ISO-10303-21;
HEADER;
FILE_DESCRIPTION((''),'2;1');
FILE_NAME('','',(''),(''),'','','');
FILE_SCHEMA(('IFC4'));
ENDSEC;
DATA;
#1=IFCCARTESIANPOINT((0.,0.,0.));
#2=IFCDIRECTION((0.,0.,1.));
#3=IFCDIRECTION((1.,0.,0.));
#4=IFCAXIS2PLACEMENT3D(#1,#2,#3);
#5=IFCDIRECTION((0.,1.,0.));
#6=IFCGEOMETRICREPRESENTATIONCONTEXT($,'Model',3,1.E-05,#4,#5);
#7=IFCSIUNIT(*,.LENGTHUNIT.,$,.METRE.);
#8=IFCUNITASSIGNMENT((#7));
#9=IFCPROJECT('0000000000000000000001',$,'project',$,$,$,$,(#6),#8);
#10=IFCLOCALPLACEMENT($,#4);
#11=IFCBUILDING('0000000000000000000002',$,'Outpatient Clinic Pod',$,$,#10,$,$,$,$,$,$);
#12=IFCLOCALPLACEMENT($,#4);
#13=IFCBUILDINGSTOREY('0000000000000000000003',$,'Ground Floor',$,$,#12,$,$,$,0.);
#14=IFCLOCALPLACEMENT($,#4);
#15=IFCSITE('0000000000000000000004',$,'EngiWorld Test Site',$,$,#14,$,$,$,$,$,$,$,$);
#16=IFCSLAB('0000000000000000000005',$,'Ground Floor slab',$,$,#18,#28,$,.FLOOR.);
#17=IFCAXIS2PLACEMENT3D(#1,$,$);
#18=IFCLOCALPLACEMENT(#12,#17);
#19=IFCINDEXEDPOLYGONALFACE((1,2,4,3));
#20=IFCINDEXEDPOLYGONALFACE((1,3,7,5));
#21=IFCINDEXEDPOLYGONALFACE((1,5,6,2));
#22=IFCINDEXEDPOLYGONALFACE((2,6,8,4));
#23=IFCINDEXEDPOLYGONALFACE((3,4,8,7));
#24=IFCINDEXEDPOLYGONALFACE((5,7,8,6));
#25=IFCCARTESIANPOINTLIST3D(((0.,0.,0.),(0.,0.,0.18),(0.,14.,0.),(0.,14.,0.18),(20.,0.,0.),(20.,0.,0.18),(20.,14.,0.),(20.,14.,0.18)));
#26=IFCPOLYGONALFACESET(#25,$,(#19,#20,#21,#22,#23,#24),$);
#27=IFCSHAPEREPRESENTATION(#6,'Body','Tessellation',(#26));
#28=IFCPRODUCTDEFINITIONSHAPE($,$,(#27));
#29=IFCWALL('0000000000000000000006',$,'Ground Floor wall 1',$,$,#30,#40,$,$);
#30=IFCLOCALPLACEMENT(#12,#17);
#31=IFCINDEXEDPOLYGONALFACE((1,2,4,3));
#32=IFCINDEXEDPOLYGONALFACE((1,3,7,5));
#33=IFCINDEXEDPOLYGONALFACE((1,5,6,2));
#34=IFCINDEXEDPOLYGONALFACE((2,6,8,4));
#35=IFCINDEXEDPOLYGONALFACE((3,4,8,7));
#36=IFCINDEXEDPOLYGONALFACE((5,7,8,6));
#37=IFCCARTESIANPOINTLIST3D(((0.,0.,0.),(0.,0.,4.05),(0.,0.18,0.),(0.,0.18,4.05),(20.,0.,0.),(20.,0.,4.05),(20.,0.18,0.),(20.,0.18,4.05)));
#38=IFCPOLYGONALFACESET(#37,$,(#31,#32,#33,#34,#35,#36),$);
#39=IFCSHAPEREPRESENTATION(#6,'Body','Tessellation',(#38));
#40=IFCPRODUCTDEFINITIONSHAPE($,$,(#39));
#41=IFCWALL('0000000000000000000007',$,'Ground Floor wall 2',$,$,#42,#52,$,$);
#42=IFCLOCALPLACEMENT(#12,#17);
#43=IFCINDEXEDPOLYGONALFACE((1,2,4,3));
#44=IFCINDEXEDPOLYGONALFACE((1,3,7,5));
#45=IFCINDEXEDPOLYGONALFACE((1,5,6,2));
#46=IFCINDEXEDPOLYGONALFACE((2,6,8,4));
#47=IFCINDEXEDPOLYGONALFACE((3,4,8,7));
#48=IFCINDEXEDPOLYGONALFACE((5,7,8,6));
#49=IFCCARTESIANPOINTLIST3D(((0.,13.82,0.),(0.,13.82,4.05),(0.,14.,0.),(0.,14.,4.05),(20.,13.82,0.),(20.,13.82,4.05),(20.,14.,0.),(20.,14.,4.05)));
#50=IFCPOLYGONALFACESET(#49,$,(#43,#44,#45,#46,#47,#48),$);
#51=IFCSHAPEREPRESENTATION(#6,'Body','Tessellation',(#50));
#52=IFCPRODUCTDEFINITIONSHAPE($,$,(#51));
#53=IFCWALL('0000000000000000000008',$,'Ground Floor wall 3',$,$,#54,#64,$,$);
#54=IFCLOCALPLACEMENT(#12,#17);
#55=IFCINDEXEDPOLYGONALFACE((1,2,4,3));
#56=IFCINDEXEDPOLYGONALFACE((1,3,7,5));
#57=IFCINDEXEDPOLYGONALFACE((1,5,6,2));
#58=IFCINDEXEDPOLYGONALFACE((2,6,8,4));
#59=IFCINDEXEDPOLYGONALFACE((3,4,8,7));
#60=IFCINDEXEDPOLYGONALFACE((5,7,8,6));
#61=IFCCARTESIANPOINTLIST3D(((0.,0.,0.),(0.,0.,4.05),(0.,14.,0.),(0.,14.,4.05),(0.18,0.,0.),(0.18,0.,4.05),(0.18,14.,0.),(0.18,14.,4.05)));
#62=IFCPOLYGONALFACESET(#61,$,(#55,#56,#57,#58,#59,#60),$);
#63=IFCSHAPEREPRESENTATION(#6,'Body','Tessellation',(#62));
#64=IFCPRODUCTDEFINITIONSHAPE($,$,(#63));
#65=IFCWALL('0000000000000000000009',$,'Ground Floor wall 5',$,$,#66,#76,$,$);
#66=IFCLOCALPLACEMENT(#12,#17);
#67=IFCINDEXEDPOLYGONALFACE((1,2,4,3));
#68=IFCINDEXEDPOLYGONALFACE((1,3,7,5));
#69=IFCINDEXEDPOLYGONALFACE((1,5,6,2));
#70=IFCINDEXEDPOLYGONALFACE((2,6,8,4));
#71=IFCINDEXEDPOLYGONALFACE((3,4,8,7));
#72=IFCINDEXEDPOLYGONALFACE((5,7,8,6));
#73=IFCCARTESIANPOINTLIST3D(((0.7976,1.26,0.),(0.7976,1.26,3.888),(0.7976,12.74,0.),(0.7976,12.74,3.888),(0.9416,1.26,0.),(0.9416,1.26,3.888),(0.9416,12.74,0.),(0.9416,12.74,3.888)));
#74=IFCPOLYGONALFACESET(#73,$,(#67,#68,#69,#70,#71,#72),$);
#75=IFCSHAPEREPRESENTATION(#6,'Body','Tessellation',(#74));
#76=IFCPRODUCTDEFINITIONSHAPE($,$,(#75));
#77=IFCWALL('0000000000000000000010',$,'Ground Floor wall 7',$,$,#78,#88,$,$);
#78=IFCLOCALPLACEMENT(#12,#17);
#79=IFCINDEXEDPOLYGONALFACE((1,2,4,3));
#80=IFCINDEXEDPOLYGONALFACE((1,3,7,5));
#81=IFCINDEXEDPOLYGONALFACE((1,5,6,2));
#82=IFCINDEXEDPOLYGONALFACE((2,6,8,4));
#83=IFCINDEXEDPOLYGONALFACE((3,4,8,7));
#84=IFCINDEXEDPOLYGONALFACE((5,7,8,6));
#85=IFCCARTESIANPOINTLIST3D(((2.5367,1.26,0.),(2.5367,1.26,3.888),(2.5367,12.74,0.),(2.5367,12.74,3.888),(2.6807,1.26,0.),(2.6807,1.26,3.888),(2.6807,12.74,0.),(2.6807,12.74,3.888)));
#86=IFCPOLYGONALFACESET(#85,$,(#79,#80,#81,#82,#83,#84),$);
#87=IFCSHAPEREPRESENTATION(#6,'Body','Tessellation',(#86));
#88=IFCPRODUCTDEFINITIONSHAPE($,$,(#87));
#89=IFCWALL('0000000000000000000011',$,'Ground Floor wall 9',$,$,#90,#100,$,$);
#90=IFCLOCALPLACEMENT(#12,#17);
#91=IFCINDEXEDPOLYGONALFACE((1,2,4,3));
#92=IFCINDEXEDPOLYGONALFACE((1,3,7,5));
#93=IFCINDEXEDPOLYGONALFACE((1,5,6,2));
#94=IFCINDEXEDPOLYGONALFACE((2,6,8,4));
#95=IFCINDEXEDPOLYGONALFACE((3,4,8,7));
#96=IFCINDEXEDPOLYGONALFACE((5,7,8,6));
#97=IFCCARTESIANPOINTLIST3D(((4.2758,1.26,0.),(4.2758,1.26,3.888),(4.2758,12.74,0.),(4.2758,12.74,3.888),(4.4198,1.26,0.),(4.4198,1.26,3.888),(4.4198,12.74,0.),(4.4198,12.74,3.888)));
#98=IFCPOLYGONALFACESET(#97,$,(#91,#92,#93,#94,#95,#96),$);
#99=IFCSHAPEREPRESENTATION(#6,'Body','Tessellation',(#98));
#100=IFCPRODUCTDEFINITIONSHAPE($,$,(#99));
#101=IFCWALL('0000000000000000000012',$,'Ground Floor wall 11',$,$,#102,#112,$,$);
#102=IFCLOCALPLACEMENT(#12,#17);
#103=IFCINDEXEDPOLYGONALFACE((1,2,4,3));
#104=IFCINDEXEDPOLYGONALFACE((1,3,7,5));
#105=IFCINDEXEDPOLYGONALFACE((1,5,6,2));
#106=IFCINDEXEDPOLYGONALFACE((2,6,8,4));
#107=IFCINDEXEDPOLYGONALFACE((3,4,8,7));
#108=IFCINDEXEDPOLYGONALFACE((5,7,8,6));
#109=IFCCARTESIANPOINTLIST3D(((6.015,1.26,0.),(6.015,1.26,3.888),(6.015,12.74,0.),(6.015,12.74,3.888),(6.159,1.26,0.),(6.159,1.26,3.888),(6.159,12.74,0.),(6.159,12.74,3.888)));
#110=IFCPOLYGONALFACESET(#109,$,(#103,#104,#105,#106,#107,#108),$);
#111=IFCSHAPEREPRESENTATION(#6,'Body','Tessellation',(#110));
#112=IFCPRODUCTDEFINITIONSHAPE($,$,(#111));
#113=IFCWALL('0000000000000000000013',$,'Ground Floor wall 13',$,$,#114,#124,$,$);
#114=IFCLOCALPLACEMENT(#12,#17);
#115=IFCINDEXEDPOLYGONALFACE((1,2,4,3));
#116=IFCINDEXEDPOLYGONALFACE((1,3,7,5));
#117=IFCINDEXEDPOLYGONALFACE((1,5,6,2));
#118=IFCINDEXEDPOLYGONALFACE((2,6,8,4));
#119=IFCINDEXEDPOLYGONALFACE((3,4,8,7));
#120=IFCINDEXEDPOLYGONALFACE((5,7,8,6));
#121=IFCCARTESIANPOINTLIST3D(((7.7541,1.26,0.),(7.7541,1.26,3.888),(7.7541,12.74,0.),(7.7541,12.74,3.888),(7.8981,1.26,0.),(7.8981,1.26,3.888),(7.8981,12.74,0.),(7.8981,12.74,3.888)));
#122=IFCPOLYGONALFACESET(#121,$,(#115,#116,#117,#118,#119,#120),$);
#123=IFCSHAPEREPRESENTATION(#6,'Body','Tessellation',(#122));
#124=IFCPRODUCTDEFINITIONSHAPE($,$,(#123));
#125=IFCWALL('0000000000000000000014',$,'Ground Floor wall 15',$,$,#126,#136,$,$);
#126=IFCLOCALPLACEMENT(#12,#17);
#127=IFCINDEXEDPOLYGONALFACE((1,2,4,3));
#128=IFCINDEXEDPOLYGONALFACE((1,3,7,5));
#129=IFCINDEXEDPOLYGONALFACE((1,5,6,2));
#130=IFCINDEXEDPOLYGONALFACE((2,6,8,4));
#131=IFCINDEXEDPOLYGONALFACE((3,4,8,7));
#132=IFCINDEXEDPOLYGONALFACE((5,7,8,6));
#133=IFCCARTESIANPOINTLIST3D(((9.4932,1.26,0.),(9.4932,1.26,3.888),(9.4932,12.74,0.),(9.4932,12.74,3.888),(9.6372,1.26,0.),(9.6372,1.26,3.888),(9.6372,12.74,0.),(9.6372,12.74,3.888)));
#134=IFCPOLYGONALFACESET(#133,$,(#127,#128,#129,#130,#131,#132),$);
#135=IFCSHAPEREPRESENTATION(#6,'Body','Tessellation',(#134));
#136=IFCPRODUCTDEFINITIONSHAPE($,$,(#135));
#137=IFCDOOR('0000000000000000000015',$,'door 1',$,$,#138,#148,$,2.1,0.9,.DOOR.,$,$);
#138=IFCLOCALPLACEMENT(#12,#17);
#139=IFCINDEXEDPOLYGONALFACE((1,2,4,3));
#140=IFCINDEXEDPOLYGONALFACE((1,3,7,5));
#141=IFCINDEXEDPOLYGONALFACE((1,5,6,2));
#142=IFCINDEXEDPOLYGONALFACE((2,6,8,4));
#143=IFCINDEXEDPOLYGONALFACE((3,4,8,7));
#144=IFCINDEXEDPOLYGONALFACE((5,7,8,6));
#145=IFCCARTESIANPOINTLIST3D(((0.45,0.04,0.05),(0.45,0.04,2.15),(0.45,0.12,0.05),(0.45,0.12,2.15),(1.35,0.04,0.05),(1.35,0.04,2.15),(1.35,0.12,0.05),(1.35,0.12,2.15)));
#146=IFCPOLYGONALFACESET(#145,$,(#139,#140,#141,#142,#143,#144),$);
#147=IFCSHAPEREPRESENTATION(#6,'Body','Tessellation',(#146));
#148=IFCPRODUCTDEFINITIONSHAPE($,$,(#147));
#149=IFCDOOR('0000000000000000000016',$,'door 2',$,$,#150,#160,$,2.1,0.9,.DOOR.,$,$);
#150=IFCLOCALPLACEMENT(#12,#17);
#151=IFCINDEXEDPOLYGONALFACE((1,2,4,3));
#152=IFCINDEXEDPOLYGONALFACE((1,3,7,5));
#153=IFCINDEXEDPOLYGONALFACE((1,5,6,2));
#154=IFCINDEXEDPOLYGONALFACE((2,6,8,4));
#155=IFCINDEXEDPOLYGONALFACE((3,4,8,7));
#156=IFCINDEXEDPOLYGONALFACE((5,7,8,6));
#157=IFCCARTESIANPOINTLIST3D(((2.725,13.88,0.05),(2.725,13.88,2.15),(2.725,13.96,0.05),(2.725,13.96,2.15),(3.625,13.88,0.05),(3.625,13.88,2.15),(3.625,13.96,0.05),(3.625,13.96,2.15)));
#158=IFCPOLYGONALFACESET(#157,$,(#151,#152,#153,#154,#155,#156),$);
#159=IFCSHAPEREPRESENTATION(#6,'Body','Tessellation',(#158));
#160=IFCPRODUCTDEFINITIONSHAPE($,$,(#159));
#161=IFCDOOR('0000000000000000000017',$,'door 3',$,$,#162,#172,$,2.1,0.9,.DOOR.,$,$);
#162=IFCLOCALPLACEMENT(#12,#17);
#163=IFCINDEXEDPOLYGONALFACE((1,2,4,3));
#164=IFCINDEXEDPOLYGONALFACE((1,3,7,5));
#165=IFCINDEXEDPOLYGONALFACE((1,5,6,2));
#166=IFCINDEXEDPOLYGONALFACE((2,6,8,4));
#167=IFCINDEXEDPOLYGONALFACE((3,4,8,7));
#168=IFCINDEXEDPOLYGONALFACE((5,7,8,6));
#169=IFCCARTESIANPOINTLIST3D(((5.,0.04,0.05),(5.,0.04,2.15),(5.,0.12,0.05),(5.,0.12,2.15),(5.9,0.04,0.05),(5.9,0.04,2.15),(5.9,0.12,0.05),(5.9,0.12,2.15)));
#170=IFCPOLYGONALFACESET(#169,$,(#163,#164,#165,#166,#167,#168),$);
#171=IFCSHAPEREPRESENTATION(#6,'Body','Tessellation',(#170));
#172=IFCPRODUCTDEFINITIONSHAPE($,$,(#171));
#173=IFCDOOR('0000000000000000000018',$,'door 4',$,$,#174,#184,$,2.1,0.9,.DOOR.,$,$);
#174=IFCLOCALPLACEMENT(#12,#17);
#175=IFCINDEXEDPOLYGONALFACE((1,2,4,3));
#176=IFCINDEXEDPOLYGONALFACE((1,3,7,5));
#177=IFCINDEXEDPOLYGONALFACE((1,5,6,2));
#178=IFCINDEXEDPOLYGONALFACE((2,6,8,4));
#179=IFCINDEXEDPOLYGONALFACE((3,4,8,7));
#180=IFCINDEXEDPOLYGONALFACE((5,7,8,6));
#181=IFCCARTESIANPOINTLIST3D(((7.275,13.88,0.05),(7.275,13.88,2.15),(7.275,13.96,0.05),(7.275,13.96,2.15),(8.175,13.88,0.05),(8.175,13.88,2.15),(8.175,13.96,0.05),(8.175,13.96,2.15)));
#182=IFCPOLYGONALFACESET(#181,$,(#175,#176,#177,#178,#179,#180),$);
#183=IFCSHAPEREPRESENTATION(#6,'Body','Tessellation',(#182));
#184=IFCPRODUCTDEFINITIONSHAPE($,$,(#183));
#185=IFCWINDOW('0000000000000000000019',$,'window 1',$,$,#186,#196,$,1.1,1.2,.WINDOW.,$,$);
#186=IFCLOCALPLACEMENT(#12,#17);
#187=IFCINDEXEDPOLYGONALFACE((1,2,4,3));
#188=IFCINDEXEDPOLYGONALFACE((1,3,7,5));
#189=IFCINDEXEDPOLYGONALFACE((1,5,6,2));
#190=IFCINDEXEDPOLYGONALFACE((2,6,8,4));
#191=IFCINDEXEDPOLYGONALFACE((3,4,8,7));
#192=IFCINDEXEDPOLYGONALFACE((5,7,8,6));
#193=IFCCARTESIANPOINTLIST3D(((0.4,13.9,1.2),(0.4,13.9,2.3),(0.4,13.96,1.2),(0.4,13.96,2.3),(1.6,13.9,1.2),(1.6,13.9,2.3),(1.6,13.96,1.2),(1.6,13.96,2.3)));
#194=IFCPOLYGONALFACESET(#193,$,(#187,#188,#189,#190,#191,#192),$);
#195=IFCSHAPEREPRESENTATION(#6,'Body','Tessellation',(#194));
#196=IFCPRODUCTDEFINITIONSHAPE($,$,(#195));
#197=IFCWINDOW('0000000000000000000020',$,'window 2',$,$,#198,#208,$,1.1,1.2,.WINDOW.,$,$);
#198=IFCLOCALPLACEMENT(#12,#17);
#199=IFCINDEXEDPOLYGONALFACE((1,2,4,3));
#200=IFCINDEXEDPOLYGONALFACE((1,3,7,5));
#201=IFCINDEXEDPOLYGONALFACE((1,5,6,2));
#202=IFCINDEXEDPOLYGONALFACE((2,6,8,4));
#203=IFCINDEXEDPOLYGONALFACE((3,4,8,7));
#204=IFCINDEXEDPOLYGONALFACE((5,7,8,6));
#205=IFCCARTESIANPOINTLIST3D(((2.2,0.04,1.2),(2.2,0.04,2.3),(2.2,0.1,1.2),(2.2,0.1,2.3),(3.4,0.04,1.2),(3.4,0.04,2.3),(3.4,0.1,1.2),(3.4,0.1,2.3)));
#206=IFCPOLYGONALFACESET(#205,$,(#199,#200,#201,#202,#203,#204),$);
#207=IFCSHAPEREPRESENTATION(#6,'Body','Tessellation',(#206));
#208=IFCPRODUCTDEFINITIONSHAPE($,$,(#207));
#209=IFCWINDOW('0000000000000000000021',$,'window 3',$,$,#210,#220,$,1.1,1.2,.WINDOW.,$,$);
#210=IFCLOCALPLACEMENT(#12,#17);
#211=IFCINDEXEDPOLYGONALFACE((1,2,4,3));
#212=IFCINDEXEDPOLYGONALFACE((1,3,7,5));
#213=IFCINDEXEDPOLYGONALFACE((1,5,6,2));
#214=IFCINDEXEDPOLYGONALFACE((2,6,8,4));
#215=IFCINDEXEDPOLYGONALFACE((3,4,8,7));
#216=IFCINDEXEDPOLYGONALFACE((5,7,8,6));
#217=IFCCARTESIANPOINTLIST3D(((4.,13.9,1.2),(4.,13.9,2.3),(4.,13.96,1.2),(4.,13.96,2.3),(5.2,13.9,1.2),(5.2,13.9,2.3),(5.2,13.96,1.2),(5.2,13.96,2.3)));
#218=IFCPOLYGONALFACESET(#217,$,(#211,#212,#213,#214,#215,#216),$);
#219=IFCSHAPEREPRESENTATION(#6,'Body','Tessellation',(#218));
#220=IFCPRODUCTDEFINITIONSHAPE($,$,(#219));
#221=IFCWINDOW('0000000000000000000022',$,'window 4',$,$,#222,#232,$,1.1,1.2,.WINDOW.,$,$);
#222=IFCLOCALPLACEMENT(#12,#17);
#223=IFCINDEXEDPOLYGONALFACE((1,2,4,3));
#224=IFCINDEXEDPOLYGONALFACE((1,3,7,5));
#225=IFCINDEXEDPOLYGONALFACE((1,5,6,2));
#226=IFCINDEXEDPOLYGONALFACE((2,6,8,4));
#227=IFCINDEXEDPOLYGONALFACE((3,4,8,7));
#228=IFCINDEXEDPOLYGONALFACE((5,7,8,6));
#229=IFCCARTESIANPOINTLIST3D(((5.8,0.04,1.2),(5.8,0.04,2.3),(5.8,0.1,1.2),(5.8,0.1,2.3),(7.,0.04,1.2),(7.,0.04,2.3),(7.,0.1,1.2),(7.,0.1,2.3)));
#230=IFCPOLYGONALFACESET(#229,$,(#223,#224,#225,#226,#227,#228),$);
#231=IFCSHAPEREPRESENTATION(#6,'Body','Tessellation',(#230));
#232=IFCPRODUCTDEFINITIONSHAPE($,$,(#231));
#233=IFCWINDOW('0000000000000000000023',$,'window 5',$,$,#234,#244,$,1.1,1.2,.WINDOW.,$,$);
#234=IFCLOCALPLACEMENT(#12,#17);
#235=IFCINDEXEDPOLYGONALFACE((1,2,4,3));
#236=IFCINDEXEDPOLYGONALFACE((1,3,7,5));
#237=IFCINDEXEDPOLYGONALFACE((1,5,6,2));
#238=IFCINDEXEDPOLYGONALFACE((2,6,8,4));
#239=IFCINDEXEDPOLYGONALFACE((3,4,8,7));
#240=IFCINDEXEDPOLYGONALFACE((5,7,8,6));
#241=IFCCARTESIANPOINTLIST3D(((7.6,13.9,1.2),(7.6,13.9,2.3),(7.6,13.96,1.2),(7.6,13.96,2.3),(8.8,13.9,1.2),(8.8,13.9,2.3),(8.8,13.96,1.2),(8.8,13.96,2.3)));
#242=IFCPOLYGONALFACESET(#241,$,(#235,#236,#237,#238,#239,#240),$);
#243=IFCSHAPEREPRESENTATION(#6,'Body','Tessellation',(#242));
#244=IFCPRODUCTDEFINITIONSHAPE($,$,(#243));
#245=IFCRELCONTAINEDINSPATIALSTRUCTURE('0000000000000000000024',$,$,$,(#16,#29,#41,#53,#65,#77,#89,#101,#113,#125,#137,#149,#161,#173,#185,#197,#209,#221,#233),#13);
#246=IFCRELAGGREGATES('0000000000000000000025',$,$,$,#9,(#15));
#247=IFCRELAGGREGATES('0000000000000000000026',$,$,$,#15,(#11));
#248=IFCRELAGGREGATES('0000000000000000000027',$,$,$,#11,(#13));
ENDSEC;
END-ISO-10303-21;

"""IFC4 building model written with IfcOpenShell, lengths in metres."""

from ifc_helpers import new_model, si_unit, direction, frame, origin_with_axes, origin_2d_with_axis, place, context, project, spatial, rectangle, extrude, element, save


model = new_model("IFC4")

# Units and contexts
model_context = context("Model", 3, precision=1e-05, world=origin_with_axes(), true_north=direction((0.0, 1.0, 0.0)))
ifc_project = project(units=[si_unit("LENGTHUNIT", "METRE")], contexts=[model_context])

# Site, building, storey
site_placement = place(None, origin_with_axes())
site = spatial("IfcSite", under=ifc_project, at=site_placement, Name="EngiWorld Test Site")
building_placement = place(None, origin_with_axes())
building = spatial("IfcBuilding", under=site, at=building_placement, Name="Outpatient Clinic Pod")
storey_placement = place(None, origin_with_axes())
storey = spatial("IfcBuildingStorey", under=building, at=storey_placement, Name="Ground Floor", Elevation=0.0)

# Slab
slab_placement = place(None, frame((10.0, 7.0, 0.0), z_axis=(0.0, 0.0, 1.0), x_axis=(1.0, 0.0, 0.0)))
element("IfcSlab", 1, at=slab_placement, inside=storey, Name="Ground Floor slab", PredefinedType="FLOOR", context=model_context, shape_type="SweptSolid", body=[
    extrude(rectangle(XDim=20.0, YDim=14.0, at=origin_2d_with_axis()), origin_with_axes(), (0.0, 0.0, 1.0), 0.18),
])

# Walls
for number, where, z_axis, x_axis, name in (
    (2, (10.0, 0.09, 0.0), (0.0, 0.0, 1.0), (1.0, 0.0, 0.0), "Ground Floor wall 1"),
    (3, (10.0, 13.91, 0.0), (0.0, 0.0, 1.0), (1.0, 0.0, 0.0), "Ground Floor wall 2"),
):
    element("IfcWall", number, at=place(None, frame(where, z_axis=z_axis, x_axis=x_axis)), inside=storey, Name=name, context=model_context, shape_type="SweptSolid", body=[
        extrude(rectangle(XDim=20.0, YDim=0.18, at=origin_2d_with_axis()), origin_with_axes(), (0.0, 0.0, 1.0), 4.05),
    ])
wall_placement = place(None, frame((0.09, 7.0, 0.0), z_axis=(0.0, 0.0, 1.0), x_axis=(1.0, 0.0, 0.0)))
element("IfcWall", 4, at=wall_placement, inside=storey, Name="Ground Floor wall 3", context=model_context, shape_type="SweptSolid", body=[
    extrude(rectangle(XDim=0.18, YDim=14.0, at=origin_2d_with_axis()), origin_with_axes(), (0.0, 0.0, 1.0), 4.05),
])
for number, where, z_axis, x_axis, name in (
    (5, (0.8696, 7.0, 0.0), (0.0, 0.0, 1.0), (1.0, 0.0, 0.0), "Ground Floor wall 5"),
    (6, (2.6087, 7.0, 0.0), (0.0, 0.0, 1.0), (1.0, 0.0, 0.0), "Ground Floor wall 7"),
    (7, (4.3478, 7.0, 0.0), (0.0, 0.0, 1.0), (1.0, 0.0, 0.0), "Ground Floor wall 9"),
    (8, (6.087, 7.0, 0.0), (0.0, 0.0, 1.0), (1.0, 0.0, 0.0), "Ground Floor wall 11"),
    (9, (7.8261, 7.0, 0.0), (0.0, 0.0, 1.0), (1.0, 0.0, 0.0), "Ground Floor wall 13"),
    (10, (9.5652, 7.0, 0.0), (0.0, 0.0, 1.0), (1.0, 0.0, 0.0), "Ground Floor wall 15"),
):
    element("IfcWall", number, at=place(None, frame(where, z_axis=z_axis, x_axis=x_axis)), inside=storey, Name=name, context=model_context, shape_type="SweptSolid", body=[
        extrude(rectangle(XDim=0.144, YDim=11.48, at=origin_2d_with_axis()), origin_with_axes(), (0.0, 0.0, 1.0), 3.888),
    ])

# Doors
for number, where, z_axis, x_axis, name in (
    (11, (0.9, 0.08, 0.05), (0.0, 0.0, 1.0), (1.0, 0.0, 0.0), "door 1"),
    (12, (3.175, 13.92, 0.05), (0.0, 0.0, 1.0), (1.0, 0.0, 0.0), "door 2"),
    (13, (5.45, 0.08, 0.05), (0.0, 0.0, 1.0), (1.0, 0.0, 0.0), "door 3"),
    (14, (7.725, 13.92, 0.05), (0.0, 0.0, 1.0), (1.0, 0.0, 0.0), "door 4"),
):
    element("IfcDoor", number, at=place(None, frame(where, z_axis=z_axis, x_axis=x_axis)), inside=storey, Name=name, OverallHeight=2.1, OverallWidth=0.9, PredefinedType="DOOR", context=model_context, shape_type="SweptSolid", body=[
        extrude(rectangle(XDim=0.9, YDim=0.08, at=origin_2d_with_axis()), origin_with_axes(), (0.0, 0.0, 1.0), 2.1),
    ])

# Windows
for number, where, z_axis, x_axis, name in (
    (15, (1.0, 13.93, 1.2), (0.0, 0.0, 1.0), (1.0, 0.0, 0.0), "window 1"),
    (16, (2.8, 0.07, 1.2), (0.0, 0.0, 1.0), (1.0, 0.0, 0.0), "window 2"),
    (17, (4.6, 13.93, 1.2), (0.0, 0.0, 1.0), (1.0, 0.0, 0.0), "window 3"),
    (18, (6.4, 0.07, 1.2), (0.0, 0.0, 1.0), (1.0, 0.0, 0.0), "window 4"),
    (19, (8.2, 13.93, 1.2), (0.0, 0.0, 1.0), (1.0, 0.0, 0.0), "window 5"),
):
    element("IfcWindow", number, at=place(None, frame(where, z_axis=z_axis, x_axis=x_axis)), inside=storey, Name=name, OverallHeight=1.1, OverallWidth=1.2, PredefinedType="WINDOW", context=model_context, shape_type="SweptSolid", body=[
        extrude(rectangle(XDim=1.2, YDim=0.06, at=origin_2d_with_axis()), origin_with_axes(), (0.0, 0.0, 1.0), 1.1),
    ])

save(model, "model.ifc")
